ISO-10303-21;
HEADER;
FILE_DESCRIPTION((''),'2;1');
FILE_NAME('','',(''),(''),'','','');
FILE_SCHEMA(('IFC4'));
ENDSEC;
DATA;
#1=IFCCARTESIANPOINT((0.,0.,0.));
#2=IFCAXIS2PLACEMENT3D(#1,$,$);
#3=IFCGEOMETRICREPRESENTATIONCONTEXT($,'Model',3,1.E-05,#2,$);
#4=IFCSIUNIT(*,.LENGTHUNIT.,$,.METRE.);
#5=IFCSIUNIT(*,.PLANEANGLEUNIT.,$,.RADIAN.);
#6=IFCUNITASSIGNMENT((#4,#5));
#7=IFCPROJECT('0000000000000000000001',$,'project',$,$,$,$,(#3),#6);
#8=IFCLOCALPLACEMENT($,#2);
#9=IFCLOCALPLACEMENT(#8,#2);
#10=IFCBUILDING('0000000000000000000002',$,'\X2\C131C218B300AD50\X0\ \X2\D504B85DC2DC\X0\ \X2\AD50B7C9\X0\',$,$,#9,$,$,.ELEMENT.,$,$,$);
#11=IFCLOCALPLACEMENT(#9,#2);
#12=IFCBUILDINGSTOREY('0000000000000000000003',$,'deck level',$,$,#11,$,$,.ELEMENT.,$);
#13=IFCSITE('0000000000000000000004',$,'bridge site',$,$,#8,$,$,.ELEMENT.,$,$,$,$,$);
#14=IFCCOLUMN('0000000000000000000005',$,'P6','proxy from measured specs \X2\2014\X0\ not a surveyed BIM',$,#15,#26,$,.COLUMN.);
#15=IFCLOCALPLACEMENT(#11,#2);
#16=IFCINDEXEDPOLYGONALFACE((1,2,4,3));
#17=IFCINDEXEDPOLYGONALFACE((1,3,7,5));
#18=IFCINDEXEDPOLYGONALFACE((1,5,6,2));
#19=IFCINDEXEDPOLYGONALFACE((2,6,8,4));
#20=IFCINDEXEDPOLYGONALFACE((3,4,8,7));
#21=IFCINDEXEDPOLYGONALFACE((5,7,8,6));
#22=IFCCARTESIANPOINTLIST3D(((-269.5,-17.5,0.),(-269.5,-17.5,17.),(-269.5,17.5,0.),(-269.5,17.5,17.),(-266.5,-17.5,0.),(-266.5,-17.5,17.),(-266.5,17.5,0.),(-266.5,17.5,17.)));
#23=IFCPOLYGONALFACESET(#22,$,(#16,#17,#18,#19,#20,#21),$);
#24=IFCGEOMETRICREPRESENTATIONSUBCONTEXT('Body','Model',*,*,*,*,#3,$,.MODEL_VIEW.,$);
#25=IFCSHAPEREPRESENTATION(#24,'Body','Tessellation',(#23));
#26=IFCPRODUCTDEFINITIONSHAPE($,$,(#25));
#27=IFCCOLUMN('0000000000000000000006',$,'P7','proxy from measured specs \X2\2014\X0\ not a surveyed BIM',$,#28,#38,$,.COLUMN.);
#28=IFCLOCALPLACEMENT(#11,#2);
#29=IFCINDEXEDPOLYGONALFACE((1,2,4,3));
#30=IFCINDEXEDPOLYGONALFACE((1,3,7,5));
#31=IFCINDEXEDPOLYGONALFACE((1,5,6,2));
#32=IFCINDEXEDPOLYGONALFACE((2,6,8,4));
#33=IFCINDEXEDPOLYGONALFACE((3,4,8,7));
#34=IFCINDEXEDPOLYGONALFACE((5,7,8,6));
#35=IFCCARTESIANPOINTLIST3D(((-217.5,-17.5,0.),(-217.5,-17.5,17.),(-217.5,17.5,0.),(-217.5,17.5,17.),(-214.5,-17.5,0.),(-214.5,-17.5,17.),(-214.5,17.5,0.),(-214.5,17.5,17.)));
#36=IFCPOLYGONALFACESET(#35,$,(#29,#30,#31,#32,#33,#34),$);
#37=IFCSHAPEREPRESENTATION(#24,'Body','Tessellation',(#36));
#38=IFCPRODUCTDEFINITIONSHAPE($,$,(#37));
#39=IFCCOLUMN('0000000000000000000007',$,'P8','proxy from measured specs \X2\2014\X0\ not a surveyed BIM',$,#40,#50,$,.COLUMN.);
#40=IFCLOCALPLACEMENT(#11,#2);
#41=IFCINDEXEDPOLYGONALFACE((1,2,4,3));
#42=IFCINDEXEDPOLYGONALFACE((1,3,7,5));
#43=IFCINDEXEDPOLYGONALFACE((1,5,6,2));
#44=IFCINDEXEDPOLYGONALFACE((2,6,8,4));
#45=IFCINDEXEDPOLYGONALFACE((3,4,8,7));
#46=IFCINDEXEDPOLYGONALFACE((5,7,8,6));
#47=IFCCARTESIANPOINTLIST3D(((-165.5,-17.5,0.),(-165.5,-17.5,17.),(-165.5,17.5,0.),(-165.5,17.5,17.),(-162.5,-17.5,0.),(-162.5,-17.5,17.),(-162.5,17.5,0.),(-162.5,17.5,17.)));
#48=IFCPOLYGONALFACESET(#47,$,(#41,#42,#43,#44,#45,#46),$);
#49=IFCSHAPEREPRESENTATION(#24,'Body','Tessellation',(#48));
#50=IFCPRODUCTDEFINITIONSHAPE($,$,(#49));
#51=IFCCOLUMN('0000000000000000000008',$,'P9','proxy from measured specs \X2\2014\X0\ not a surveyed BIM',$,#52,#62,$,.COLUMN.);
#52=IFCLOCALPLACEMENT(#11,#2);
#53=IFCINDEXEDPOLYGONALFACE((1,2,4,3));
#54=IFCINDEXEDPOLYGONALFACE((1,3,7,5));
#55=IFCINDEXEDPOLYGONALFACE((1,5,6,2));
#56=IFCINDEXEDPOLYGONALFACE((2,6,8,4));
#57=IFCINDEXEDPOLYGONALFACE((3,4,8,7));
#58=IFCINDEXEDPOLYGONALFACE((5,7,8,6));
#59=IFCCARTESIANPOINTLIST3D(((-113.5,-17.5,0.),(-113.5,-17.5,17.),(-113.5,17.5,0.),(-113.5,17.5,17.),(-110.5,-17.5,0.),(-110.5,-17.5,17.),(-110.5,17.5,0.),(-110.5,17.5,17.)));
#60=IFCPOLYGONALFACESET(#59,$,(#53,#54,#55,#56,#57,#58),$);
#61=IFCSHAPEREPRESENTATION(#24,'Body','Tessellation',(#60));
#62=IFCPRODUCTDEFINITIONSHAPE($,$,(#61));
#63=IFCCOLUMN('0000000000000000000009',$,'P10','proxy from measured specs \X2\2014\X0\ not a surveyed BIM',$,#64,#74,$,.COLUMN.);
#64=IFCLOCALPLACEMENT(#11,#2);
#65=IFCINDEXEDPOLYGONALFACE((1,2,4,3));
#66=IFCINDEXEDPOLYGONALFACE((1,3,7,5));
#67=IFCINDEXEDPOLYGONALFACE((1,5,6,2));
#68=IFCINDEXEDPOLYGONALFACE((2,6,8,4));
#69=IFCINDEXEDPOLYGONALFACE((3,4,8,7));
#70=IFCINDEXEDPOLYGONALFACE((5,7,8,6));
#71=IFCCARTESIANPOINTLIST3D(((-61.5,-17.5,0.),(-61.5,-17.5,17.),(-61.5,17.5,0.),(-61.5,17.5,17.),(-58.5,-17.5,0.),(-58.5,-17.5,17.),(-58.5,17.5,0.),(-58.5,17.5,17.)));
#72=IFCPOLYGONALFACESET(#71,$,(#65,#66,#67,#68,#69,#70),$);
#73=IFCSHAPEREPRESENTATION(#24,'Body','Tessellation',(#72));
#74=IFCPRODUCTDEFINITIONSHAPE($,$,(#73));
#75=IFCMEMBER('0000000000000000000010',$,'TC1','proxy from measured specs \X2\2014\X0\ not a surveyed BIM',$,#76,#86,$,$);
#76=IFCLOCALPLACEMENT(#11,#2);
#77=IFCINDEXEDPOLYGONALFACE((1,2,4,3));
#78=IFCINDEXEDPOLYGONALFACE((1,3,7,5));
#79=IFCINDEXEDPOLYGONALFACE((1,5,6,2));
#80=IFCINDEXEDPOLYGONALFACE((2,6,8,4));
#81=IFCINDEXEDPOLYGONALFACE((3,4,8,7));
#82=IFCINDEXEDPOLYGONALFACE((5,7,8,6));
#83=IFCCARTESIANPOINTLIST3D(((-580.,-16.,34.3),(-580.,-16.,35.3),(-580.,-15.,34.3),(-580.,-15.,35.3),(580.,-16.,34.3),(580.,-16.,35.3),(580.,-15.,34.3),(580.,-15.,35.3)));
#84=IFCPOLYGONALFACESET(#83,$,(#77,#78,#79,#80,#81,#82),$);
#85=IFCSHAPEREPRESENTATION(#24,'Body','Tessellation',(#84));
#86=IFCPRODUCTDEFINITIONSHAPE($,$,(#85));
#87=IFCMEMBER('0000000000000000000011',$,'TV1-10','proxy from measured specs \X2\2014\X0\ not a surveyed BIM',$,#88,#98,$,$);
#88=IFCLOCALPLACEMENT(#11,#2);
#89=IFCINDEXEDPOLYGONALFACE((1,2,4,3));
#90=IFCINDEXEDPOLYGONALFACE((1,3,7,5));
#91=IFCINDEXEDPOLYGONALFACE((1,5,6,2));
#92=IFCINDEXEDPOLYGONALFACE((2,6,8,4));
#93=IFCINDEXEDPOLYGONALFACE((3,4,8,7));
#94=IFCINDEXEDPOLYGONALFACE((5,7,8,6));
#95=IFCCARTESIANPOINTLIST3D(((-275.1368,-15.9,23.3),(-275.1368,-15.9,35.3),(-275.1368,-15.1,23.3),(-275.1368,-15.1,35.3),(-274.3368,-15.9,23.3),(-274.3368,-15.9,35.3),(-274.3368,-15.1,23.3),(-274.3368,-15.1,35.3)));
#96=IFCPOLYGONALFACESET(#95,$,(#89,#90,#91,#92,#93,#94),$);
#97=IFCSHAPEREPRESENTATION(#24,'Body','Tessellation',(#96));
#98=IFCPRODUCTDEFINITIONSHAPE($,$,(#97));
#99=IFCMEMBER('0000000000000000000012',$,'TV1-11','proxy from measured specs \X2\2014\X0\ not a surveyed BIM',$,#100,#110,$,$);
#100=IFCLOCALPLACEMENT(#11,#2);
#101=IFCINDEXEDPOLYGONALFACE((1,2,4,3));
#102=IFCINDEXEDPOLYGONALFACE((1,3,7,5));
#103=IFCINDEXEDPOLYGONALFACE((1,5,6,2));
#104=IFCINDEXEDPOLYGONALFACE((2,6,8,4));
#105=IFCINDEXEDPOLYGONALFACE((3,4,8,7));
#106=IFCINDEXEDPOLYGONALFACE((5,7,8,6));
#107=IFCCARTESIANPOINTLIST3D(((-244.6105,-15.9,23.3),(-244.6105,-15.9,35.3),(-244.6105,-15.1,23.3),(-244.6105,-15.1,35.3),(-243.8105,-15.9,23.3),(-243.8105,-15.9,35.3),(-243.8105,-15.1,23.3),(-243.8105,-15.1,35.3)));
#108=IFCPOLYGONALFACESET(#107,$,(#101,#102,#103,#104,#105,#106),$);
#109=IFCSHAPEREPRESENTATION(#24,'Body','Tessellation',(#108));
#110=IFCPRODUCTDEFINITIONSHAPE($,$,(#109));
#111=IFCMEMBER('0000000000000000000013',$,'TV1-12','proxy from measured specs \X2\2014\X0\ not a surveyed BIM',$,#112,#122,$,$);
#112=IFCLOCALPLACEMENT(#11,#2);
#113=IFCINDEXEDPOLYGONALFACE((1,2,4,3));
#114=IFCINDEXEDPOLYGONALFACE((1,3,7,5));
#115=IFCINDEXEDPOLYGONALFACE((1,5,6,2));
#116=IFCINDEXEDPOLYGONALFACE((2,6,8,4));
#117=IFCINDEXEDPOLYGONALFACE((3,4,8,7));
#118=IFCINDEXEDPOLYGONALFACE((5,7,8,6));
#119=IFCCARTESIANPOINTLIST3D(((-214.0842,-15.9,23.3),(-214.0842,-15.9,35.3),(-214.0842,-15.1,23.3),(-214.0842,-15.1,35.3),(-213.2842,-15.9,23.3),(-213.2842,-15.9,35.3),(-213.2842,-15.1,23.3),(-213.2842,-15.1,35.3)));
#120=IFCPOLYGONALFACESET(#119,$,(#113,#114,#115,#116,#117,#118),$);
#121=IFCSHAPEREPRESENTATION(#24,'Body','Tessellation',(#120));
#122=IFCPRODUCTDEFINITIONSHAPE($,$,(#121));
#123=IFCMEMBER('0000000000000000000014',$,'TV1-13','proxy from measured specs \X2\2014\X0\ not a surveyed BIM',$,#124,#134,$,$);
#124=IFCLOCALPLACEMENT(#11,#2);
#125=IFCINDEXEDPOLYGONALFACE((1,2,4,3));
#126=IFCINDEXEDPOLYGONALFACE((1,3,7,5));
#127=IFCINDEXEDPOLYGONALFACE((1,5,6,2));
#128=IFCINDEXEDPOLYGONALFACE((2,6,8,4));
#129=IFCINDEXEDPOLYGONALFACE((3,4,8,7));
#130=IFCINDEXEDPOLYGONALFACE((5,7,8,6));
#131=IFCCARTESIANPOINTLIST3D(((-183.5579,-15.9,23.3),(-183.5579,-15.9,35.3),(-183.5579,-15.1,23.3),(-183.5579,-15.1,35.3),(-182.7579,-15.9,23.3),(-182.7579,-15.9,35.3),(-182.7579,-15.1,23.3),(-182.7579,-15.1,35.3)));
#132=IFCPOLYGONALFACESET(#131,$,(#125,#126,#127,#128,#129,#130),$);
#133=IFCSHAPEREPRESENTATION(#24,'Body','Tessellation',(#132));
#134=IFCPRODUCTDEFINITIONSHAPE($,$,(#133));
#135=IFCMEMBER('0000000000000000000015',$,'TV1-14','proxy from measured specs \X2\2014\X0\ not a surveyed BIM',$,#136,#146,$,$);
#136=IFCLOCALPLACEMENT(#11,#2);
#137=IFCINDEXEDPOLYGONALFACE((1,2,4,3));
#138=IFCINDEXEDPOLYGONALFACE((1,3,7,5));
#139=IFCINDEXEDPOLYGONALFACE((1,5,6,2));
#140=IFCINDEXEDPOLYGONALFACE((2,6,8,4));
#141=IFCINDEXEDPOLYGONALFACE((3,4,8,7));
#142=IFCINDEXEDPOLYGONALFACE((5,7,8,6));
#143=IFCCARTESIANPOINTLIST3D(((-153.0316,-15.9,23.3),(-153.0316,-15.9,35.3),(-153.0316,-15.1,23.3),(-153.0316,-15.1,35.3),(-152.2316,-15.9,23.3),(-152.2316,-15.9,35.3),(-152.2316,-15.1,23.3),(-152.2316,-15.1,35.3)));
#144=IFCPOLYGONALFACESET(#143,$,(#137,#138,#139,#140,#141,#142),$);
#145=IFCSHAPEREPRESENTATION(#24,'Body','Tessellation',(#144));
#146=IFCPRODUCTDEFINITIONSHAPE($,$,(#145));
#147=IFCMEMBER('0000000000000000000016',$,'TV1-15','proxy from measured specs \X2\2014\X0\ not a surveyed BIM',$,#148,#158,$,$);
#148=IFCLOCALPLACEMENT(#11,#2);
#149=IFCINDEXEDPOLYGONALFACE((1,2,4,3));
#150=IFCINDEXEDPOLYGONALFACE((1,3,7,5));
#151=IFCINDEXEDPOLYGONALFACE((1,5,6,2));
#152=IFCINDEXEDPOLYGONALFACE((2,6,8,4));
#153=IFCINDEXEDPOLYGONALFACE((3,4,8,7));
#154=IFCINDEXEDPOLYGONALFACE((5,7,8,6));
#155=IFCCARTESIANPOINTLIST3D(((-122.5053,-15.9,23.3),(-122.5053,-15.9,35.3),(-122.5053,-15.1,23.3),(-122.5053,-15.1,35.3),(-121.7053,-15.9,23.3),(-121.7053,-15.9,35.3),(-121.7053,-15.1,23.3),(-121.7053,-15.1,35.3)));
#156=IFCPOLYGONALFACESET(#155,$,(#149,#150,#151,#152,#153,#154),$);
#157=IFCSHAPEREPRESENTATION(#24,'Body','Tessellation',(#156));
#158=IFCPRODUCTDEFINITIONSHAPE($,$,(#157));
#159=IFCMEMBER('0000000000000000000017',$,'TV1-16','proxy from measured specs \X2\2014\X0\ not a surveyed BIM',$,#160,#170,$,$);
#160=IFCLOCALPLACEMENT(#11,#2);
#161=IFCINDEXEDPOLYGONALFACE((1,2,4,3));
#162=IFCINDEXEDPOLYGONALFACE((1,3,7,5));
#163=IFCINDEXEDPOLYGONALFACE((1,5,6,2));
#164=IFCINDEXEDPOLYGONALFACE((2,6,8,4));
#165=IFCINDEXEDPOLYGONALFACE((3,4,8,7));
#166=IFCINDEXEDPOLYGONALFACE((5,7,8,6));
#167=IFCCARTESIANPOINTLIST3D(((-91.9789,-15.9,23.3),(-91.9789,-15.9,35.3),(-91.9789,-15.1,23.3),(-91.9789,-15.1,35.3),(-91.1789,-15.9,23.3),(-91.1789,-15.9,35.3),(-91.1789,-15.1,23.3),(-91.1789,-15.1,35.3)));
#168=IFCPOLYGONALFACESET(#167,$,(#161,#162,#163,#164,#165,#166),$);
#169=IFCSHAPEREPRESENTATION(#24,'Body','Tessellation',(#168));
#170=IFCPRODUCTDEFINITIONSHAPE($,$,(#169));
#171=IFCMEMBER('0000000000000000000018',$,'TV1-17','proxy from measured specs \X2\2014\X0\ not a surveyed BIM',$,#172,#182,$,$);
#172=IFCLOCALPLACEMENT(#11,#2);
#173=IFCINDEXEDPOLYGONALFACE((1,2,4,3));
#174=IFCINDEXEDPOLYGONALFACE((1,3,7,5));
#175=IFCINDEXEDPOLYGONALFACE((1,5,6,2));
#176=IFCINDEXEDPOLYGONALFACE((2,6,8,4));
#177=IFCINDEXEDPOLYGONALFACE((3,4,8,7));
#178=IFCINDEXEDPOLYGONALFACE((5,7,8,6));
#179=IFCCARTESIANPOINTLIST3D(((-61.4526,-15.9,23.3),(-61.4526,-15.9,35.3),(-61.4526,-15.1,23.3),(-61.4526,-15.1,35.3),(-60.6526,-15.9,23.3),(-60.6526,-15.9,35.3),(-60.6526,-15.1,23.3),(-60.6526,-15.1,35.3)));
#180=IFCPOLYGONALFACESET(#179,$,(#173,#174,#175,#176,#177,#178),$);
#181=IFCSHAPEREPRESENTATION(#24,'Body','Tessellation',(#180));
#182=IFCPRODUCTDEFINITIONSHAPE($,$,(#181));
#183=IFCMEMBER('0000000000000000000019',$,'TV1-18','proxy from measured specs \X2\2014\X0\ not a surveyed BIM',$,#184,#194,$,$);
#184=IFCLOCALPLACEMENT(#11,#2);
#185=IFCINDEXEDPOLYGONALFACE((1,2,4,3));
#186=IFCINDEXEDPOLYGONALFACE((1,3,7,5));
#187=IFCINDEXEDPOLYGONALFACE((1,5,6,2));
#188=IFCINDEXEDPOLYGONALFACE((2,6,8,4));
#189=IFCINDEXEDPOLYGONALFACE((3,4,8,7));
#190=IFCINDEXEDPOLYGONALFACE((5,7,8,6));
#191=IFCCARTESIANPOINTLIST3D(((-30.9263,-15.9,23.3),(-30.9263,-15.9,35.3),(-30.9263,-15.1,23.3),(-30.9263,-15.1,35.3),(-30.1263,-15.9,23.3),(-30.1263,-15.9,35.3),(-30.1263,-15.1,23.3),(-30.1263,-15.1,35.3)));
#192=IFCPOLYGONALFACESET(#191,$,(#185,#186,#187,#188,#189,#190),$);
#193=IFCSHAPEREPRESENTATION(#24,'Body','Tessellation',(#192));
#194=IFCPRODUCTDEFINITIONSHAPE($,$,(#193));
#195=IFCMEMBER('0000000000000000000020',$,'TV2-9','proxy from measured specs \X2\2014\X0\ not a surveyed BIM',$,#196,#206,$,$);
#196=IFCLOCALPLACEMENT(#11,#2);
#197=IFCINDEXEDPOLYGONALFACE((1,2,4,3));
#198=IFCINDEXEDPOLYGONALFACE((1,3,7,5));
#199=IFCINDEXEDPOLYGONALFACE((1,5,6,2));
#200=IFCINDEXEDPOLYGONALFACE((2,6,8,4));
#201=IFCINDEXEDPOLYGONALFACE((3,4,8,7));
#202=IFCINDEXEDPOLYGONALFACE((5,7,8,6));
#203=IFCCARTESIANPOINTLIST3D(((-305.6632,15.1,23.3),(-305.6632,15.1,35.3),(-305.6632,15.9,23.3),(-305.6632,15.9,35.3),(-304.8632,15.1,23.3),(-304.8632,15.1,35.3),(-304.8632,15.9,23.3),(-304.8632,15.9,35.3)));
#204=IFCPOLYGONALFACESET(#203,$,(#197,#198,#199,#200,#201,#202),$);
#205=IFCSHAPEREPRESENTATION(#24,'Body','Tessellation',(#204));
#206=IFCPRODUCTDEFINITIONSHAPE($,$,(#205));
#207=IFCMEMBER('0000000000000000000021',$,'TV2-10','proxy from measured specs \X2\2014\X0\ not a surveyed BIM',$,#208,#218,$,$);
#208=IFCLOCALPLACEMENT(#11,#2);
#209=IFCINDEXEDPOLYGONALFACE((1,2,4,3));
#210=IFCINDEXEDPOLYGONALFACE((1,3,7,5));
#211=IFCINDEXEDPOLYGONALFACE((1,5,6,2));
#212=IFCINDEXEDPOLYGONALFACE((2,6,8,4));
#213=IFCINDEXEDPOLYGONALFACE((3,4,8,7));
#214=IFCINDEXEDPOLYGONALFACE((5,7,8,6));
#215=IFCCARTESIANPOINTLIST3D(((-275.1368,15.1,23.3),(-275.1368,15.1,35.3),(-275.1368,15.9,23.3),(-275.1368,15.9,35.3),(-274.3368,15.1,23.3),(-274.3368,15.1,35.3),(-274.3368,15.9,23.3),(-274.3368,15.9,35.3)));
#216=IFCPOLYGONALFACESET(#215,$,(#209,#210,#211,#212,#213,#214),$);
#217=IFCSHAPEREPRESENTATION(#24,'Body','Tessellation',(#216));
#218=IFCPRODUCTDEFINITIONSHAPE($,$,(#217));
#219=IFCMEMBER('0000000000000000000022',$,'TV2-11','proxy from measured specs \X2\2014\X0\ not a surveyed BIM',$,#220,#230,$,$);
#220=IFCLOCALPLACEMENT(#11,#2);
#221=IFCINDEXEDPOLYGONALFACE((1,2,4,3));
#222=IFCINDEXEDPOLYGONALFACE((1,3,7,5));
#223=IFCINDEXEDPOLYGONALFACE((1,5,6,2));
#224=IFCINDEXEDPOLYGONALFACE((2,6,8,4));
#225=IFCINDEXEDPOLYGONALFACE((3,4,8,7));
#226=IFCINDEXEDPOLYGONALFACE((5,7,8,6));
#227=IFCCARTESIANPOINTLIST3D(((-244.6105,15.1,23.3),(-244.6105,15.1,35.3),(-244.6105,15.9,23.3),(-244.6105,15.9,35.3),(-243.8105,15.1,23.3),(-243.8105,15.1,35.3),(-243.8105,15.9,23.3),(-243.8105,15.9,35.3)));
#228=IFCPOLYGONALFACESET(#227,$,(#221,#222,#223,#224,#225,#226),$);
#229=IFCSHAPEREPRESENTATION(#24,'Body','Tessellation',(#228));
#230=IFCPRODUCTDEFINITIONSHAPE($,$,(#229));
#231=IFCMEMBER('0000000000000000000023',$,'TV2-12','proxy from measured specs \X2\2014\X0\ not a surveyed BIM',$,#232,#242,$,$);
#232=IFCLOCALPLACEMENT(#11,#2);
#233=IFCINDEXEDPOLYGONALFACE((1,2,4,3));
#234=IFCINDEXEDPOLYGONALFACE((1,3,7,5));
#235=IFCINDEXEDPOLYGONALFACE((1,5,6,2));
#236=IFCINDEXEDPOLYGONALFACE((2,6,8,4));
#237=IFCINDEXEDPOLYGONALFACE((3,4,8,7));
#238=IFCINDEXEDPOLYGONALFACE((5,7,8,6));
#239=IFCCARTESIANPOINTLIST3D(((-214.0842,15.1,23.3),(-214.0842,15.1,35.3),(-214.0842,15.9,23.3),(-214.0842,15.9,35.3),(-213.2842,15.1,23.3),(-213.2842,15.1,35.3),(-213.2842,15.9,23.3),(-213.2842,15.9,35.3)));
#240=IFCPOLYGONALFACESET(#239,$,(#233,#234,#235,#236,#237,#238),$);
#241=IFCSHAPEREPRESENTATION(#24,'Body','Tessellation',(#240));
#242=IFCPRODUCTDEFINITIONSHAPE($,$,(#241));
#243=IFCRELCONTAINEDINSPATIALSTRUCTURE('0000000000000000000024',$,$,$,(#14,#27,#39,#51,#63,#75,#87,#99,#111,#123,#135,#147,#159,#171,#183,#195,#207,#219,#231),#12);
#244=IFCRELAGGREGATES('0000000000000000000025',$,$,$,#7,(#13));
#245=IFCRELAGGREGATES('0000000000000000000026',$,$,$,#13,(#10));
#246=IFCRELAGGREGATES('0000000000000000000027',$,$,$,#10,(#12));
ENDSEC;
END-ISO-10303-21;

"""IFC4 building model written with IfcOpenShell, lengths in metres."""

from ifc_helpers import new_model, si_unit, frame, origin, origin_2d, place, context, subcontext, project, spatial, rectangle, extrude, element, save


model = new_model("IFC4")

# Units and contexts
model_context = context("Model", 3, precision=1e-05, world=origin())
body_context = subcontext(model_context, "Body", "Model", "MODEL_VIEW")
ifc_project = project(units=[si_unit("LENGTHUNIT", "METRE"), si_unit("PLANEANGLEUNIT", "RADIAN")], contexts=[model_context])

# Site, building, storey
site_placement = place(None, origin())
site = spatial("IfcSite", under=ifc_project, at=site_placement, Name="bridge site", CompositionType="ELEMENT")
building_placement = place(site_placement, origin())
building = spatial("IfcBuilding", under=site, at=building_placement, Name="성수대교 프록시 교량", CompositionType="ELEMENT")
storey_placement = place(building_placement, origin())
storey = spatial("IfcBuildingStorey", under=building, at=storey_placement, Name="deck level", CompositionType="ELEMENT")

# Columns
for number, where, name in (
    (1, (-268.0, 0.0, 0.0), "P6"),
    (2, (-216.0, 0.0, 0.0), "P7"),
    (3, (-164.0, 0.0, 0.0), "P8"),
    (4, (-112.0, 0.0, 0.0), "P9"),
    (5, (-60.0, 0.0, 0.0), "P10"),
):
    element("IfcColumn", number, at=place(storey_placement, frame(where)), inside=storey, Name=name, Description="proxy from measured specs — not a surveyed BIM", PredefinedType="COLUMN", context=body_context, shape_type="SweptSolid", body=[
        extrude(rectangle(XDim=3.0, YDim=35.0, at=origin_2d()), origin(), (0.0, 0.0, 1.0), 17.0),
    ])

# Members
member_1_placement = place(storey_placement, frame((0.0, -15.5, 34.3)))
element("IfcMember", 6, at=member_1_placement, inside=storey, Name="TC1", Description="proxy from measured specs — not a surveyed BIM", context=body_context, shape_type="SweptSolid", body=[
    extrude(rectangle(XDim=1160.0, YDim=1.0, at=origin_2d()), origin(), (0.0, 0.0, 1.0), 1.0),
])
member_2_placement = place(storey_placement, frame((-274.7368, -15.5, 23.3)))
element("IfcMember", 7, at=member_2_placement, inside=storey, Name="TV1-10", Description="proxy from measured specs — not a surveyed BIM", context=body_context, shape_type="SweptSolid", body=[
    extrude(rectangle(XDim=0.8, YDim=0.8, at=origin_2d()), origin(), (0.0, 0.0, 1.0), 12.0),
])
for number, where, name in (
    (8, (-244.2105, -15.5, 23.3), "TV1-11"),
    (9, (-213.6842, -15.5, 23.3), "TV1-12"),
    (10, (-183.1579, -15.5, 23.3), "TV1-13"),
    (11, (-152.6316, -15.5, 23.3), "TV1-14"),
    (12, (-122.1053, -15.5, 23.3), "TV1-15"),
    (13, (-91.5789, -15.5, 23.3), "TV1-16"),
):
    element("IfcMember", number, at=place(storey_placement, frame(where)), inside=storey, Name=name, Description="proxy from measured specs — not a surveyed BIM", context=body_context, shape_type="SweptSolid", body=[
        extrude(rectangle(XDim=0.8, YDim=0.8, at=origin_2d()), origin(), (0.0, 0.0, 1.0), 12.0),
    ])
for number, where, name in (
    (14, (-61.0526, -15.5, 23.3), "TV1-17"),
    (15, (-30.5263, -15.5, 23.3), "TV1-18"),
):
    element("IfcMember", number, at=place(storey_placement, frame(where)), inside=storey, Name=name, Description="proxy from measured specs — not a surveyed BIM", context=body_context, shape_type="SweptSolid", body=[
        extrude(rectangle(XDim=0.8, YDim=0.8, at=origin_2d()), origin(), (0.0, 0.0, 1.0), 12.0),
    ])
for number, where, name in (
    (16, (-305.2632, 15.5, 23.3), "TV2-9"),
    (17, (-274.7368, 15.5, 23.3), "TV2-10"),
):
    element("IfcMember", number, at=place(storey_placement, frame(where)), inside=storey, Name=name, Description="proxy from measured specs — not a surveyed BIM", context=body_context, shape_type="SweptSolid", body=[
        extrude(rectangle(XDim=0.8, YDim=0.8, at=origin_2d()), origin(), (0.0, 0.0, 1.0), 12.0),
    ])
for number, where, name in (
    (18, (-244.2105, 15.5, 23.3), "TV2-11"),
    (19, (-213.6842, 15.5, 23.3), "TV2-12"),
):
    element("IfcMember", number, at=place(storey_placement, frame(where)), inside=storey, Name=name, Description="proxy from measured specs — not a surveyed BIM", context=body_context, shape_type="SweptSolid", body=[
        extrude(rectangle(XDim=0.8, YDim=0.8, at=origin_2d()), origin(), (0.0, 0.0, 1.0), 12.0),
    ])

save(model, "model.ifc")
